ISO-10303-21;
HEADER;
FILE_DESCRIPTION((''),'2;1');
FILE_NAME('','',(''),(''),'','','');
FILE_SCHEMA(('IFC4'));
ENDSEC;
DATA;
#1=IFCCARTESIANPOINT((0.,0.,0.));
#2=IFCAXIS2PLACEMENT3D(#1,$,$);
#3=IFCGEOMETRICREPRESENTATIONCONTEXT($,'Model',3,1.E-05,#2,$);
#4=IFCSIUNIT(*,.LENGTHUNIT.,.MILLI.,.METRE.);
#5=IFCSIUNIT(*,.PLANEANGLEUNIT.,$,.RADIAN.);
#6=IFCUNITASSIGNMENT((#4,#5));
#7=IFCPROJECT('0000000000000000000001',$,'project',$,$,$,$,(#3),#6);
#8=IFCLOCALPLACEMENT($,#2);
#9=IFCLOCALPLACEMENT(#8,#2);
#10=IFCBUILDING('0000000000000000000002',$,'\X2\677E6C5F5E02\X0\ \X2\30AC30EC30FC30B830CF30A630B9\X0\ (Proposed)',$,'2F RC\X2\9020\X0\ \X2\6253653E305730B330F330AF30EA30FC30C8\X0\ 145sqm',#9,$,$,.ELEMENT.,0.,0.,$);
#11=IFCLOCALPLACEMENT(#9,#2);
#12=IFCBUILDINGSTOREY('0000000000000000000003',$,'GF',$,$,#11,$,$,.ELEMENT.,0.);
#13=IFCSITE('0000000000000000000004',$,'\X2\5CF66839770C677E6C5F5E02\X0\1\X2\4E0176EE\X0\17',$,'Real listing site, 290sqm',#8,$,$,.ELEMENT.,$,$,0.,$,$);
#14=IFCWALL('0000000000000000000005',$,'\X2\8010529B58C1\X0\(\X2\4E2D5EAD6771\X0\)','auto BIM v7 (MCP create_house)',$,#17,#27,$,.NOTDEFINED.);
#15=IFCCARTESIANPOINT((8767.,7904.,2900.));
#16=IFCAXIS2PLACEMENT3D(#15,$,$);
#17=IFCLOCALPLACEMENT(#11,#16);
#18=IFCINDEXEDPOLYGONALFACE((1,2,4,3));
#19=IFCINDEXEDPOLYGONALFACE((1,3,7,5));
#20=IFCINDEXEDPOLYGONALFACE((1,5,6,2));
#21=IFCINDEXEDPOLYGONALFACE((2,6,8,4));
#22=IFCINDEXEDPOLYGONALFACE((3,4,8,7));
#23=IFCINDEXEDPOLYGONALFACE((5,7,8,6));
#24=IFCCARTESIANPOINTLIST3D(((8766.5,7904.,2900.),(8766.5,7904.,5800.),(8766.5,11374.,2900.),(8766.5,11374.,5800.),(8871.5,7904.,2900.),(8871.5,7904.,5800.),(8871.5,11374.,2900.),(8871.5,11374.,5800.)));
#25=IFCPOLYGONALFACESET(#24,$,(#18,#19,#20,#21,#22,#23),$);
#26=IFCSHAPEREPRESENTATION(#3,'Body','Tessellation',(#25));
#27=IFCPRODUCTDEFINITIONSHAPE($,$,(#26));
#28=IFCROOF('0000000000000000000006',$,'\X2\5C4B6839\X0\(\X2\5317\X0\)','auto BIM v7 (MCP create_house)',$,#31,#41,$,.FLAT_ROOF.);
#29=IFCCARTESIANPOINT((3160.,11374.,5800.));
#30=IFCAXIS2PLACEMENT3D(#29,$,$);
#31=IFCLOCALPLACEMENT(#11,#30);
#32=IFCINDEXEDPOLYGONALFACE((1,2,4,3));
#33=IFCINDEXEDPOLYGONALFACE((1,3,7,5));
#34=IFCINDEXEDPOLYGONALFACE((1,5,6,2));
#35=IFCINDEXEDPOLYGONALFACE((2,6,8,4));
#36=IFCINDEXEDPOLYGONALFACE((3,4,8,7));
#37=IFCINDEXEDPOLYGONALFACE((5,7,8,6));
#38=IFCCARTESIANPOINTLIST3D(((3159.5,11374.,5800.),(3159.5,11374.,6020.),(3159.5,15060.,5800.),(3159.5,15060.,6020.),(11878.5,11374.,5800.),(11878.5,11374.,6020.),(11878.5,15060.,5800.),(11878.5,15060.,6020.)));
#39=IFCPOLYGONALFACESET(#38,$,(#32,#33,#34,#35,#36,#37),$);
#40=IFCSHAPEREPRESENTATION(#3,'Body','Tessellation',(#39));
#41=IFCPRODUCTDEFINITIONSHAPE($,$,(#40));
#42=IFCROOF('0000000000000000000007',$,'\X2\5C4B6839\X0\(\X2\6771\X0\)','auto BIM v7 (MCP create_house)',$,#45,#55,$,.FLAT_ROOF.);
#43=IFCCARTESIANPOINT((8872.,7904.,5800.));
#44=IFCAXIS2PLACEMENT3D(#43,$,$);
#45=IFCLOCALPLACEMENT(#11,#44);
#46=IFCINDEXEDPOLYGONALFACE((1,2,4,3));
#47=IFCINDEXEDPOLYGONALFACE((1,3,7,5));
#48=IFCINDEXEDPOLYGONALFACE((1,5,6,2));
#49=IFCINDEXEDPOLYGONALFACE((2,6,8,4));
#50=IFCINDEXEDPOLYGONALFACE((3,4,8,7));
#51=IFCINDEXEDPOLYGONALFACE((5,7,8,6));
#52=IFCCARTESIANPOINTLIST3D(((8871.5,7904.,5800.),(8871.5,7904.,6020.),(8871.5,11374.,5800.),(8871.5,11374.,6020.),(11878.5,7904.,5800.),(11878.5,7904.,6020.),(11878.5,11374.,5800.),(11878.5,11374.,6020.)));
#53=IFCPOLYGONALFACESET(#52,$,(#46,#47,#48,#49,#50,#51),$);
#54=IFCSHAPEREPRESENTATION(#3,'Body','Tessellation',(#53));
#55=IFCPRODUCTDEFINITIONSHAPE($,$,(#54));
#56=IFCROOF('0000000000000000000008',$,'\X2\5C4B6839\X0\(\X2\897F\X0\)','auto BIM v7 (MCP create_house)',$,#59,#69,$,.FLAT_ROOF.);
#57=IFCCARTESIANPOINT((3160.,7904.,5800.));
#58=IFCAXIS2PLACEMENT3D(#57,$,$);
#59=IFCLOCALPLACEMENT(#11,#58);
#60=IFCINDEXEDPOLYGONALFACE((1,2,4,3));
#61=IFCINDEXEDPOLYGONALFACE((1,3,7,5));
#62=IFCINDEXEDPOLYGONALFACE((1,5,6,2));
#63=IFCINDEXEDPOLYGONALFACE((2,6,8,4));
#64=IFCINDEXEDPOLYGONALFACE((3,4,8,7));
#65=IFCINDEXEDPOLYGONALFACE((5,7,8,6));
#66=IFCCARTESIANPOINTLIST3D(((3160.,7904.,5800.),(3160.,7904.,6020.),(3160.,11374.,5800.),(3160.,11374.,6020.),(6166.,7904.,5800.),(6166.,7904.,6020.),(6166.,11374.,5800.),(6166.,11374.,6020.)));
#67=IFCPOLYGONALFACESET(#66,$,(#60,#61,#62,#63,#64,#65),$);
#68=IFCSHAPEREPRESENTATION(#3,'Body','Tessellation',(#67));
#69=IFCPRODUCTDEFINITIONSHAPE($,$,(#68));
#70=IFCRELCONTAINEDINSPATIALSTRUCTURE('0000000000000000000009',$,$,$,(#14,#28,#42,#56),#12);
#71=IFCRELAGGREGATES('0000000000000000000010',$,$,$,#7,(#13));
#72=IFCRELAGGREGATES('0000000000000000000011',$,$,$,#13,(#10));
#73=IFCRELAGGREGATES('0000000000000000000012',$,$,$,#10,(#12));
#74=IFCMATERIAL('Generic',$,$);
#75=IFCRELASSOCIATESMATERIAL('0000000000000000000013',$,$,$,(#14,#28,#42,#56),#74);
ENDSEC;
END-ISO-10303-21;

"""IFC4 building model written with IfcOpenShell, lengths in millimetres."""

from ifc_helpers import new_model, si_unit, frame, frame_2d, origin, place, context, project, spatial, rectangle, extrude, material, element, save


model = new_model("IFC4")

# Units and contexts
model_context = context("Model", 3, precision=1e-05, world=origin())
ifc_project = project(units=[si_unit("LENGTHUNIT", "METRE", prefix="MILLI"), si_unit("PLANEANGLEUNIT", "RADIAN")], contexts=[model_context])

# Site, building, storey
site_placement = place(None, origin())
site = spatial("IfcSite", under=ifc_project, at=site_placement, Name="島根県松江市1丁目17", ObjectType="Real listing site, 290sqm", CompositionType="ELEMENT", RefElevation=0.0)
building_placement = place(site_placement, origin())
building = spatial("IfcBuilding", under=site, at=building_placement, Name="松江市 ガレージハウス (Proposed)", ObjectType="2F RC造 打放しコンクリート 145sqm", CompositionType="ELEMENT", ElevationOfRefHeight=0.0, ElevationOfTerrain=0.0)
storey_placement = place(building_placement, origin())
storey = spatial("IfcBuildingStorey", under=building, at=storey_placement, Name="GF", CompositionType="ELEMENT", Elevation=0.0)

# Shared definitions
ifc_material = material(Name="Generic")

# Wall
wall_1_placement = place(storey_placement, frame((8767.0, 7904.0, 2900.0)))
element("IfcWall", 1, at=wall_1_placement, inside=storey, material=ifc_material, Name="耐力壁(中庭東)", Description="auto BIM v7 (MCP create_house)", PredefinedType="NOTDEFINED", context=model_context, shape_type="SweptSolid", body=[
    extrude(rectangle(XDim=105.0, YDim=3470.0, at=frame_2d((52.0, 1735.0))), frame((8767.0, 7904.0, 2900.0)), (0.0, 0.0, 1.0), 2900.0),
])

# Roofs
roof_1_placement = place(storey_placement, frame((3160.0, 11374.0, 5800.0)))
element("IfcRoof", 2, at=roof_1_placement, inside=storey, material=ifc_material, Name="屋根(北)", Description="auto BIM v7 (MCP create_house)", PredefinedType="FLAT_ROOF", context=model_context, shape_type="SweptSolid", body=[
    extrude(rectangle(XDim=8719.0, YDim=3686.0, at=frame_2d((4359.0, 1843.0))), frame((3160.0, 11374.0, 5800.0)), (0.0, 0.0, 1.0), 220.0),
])
roof_2_placement = place(storey_placement, frame((8872.0, 7904.0, 5800.0)))
element("IfcRoof", 3, at=roof_2_placement, inside=storey, material=ifc_material, Name="屋根(東)", Description="auto BIM v7 (MCP create_house)", PredefinedType="FLAT_ROOF", context=model_context, shape_type="SweptSolid", body=[
    extrude(rectangle(XDim=3007.0, YDim=3470.0, at=frame_2d((1503.0, 1735.0))), frame((8872.0, 7904.0, 5800.0)), (0.0, 0.0, 1.0), 220.0),
])
roof_3_placement = place(storey_placement, frame((3160.0, 7904.0, 5800.0)))
element("IfcRoof", 4, at=roof_3_placement, inside=storey, material=ifc_material, Name="屋根(西)", Description="auto BIM v7 (MCP create_house)", PredefinedType="FLAT_ROOF", context=model_context, shape_type="SweptSolid", body=[
    extrude(rectangle(XDim=3006.0, YDim=3470.0, at=frame_2d((1503.0, 1735.0))), frame((3160.0, 7904.0, 5800.0)), (0.0, 0.0, 1.0), 220.0),
])

save(model, "model.ifc")
